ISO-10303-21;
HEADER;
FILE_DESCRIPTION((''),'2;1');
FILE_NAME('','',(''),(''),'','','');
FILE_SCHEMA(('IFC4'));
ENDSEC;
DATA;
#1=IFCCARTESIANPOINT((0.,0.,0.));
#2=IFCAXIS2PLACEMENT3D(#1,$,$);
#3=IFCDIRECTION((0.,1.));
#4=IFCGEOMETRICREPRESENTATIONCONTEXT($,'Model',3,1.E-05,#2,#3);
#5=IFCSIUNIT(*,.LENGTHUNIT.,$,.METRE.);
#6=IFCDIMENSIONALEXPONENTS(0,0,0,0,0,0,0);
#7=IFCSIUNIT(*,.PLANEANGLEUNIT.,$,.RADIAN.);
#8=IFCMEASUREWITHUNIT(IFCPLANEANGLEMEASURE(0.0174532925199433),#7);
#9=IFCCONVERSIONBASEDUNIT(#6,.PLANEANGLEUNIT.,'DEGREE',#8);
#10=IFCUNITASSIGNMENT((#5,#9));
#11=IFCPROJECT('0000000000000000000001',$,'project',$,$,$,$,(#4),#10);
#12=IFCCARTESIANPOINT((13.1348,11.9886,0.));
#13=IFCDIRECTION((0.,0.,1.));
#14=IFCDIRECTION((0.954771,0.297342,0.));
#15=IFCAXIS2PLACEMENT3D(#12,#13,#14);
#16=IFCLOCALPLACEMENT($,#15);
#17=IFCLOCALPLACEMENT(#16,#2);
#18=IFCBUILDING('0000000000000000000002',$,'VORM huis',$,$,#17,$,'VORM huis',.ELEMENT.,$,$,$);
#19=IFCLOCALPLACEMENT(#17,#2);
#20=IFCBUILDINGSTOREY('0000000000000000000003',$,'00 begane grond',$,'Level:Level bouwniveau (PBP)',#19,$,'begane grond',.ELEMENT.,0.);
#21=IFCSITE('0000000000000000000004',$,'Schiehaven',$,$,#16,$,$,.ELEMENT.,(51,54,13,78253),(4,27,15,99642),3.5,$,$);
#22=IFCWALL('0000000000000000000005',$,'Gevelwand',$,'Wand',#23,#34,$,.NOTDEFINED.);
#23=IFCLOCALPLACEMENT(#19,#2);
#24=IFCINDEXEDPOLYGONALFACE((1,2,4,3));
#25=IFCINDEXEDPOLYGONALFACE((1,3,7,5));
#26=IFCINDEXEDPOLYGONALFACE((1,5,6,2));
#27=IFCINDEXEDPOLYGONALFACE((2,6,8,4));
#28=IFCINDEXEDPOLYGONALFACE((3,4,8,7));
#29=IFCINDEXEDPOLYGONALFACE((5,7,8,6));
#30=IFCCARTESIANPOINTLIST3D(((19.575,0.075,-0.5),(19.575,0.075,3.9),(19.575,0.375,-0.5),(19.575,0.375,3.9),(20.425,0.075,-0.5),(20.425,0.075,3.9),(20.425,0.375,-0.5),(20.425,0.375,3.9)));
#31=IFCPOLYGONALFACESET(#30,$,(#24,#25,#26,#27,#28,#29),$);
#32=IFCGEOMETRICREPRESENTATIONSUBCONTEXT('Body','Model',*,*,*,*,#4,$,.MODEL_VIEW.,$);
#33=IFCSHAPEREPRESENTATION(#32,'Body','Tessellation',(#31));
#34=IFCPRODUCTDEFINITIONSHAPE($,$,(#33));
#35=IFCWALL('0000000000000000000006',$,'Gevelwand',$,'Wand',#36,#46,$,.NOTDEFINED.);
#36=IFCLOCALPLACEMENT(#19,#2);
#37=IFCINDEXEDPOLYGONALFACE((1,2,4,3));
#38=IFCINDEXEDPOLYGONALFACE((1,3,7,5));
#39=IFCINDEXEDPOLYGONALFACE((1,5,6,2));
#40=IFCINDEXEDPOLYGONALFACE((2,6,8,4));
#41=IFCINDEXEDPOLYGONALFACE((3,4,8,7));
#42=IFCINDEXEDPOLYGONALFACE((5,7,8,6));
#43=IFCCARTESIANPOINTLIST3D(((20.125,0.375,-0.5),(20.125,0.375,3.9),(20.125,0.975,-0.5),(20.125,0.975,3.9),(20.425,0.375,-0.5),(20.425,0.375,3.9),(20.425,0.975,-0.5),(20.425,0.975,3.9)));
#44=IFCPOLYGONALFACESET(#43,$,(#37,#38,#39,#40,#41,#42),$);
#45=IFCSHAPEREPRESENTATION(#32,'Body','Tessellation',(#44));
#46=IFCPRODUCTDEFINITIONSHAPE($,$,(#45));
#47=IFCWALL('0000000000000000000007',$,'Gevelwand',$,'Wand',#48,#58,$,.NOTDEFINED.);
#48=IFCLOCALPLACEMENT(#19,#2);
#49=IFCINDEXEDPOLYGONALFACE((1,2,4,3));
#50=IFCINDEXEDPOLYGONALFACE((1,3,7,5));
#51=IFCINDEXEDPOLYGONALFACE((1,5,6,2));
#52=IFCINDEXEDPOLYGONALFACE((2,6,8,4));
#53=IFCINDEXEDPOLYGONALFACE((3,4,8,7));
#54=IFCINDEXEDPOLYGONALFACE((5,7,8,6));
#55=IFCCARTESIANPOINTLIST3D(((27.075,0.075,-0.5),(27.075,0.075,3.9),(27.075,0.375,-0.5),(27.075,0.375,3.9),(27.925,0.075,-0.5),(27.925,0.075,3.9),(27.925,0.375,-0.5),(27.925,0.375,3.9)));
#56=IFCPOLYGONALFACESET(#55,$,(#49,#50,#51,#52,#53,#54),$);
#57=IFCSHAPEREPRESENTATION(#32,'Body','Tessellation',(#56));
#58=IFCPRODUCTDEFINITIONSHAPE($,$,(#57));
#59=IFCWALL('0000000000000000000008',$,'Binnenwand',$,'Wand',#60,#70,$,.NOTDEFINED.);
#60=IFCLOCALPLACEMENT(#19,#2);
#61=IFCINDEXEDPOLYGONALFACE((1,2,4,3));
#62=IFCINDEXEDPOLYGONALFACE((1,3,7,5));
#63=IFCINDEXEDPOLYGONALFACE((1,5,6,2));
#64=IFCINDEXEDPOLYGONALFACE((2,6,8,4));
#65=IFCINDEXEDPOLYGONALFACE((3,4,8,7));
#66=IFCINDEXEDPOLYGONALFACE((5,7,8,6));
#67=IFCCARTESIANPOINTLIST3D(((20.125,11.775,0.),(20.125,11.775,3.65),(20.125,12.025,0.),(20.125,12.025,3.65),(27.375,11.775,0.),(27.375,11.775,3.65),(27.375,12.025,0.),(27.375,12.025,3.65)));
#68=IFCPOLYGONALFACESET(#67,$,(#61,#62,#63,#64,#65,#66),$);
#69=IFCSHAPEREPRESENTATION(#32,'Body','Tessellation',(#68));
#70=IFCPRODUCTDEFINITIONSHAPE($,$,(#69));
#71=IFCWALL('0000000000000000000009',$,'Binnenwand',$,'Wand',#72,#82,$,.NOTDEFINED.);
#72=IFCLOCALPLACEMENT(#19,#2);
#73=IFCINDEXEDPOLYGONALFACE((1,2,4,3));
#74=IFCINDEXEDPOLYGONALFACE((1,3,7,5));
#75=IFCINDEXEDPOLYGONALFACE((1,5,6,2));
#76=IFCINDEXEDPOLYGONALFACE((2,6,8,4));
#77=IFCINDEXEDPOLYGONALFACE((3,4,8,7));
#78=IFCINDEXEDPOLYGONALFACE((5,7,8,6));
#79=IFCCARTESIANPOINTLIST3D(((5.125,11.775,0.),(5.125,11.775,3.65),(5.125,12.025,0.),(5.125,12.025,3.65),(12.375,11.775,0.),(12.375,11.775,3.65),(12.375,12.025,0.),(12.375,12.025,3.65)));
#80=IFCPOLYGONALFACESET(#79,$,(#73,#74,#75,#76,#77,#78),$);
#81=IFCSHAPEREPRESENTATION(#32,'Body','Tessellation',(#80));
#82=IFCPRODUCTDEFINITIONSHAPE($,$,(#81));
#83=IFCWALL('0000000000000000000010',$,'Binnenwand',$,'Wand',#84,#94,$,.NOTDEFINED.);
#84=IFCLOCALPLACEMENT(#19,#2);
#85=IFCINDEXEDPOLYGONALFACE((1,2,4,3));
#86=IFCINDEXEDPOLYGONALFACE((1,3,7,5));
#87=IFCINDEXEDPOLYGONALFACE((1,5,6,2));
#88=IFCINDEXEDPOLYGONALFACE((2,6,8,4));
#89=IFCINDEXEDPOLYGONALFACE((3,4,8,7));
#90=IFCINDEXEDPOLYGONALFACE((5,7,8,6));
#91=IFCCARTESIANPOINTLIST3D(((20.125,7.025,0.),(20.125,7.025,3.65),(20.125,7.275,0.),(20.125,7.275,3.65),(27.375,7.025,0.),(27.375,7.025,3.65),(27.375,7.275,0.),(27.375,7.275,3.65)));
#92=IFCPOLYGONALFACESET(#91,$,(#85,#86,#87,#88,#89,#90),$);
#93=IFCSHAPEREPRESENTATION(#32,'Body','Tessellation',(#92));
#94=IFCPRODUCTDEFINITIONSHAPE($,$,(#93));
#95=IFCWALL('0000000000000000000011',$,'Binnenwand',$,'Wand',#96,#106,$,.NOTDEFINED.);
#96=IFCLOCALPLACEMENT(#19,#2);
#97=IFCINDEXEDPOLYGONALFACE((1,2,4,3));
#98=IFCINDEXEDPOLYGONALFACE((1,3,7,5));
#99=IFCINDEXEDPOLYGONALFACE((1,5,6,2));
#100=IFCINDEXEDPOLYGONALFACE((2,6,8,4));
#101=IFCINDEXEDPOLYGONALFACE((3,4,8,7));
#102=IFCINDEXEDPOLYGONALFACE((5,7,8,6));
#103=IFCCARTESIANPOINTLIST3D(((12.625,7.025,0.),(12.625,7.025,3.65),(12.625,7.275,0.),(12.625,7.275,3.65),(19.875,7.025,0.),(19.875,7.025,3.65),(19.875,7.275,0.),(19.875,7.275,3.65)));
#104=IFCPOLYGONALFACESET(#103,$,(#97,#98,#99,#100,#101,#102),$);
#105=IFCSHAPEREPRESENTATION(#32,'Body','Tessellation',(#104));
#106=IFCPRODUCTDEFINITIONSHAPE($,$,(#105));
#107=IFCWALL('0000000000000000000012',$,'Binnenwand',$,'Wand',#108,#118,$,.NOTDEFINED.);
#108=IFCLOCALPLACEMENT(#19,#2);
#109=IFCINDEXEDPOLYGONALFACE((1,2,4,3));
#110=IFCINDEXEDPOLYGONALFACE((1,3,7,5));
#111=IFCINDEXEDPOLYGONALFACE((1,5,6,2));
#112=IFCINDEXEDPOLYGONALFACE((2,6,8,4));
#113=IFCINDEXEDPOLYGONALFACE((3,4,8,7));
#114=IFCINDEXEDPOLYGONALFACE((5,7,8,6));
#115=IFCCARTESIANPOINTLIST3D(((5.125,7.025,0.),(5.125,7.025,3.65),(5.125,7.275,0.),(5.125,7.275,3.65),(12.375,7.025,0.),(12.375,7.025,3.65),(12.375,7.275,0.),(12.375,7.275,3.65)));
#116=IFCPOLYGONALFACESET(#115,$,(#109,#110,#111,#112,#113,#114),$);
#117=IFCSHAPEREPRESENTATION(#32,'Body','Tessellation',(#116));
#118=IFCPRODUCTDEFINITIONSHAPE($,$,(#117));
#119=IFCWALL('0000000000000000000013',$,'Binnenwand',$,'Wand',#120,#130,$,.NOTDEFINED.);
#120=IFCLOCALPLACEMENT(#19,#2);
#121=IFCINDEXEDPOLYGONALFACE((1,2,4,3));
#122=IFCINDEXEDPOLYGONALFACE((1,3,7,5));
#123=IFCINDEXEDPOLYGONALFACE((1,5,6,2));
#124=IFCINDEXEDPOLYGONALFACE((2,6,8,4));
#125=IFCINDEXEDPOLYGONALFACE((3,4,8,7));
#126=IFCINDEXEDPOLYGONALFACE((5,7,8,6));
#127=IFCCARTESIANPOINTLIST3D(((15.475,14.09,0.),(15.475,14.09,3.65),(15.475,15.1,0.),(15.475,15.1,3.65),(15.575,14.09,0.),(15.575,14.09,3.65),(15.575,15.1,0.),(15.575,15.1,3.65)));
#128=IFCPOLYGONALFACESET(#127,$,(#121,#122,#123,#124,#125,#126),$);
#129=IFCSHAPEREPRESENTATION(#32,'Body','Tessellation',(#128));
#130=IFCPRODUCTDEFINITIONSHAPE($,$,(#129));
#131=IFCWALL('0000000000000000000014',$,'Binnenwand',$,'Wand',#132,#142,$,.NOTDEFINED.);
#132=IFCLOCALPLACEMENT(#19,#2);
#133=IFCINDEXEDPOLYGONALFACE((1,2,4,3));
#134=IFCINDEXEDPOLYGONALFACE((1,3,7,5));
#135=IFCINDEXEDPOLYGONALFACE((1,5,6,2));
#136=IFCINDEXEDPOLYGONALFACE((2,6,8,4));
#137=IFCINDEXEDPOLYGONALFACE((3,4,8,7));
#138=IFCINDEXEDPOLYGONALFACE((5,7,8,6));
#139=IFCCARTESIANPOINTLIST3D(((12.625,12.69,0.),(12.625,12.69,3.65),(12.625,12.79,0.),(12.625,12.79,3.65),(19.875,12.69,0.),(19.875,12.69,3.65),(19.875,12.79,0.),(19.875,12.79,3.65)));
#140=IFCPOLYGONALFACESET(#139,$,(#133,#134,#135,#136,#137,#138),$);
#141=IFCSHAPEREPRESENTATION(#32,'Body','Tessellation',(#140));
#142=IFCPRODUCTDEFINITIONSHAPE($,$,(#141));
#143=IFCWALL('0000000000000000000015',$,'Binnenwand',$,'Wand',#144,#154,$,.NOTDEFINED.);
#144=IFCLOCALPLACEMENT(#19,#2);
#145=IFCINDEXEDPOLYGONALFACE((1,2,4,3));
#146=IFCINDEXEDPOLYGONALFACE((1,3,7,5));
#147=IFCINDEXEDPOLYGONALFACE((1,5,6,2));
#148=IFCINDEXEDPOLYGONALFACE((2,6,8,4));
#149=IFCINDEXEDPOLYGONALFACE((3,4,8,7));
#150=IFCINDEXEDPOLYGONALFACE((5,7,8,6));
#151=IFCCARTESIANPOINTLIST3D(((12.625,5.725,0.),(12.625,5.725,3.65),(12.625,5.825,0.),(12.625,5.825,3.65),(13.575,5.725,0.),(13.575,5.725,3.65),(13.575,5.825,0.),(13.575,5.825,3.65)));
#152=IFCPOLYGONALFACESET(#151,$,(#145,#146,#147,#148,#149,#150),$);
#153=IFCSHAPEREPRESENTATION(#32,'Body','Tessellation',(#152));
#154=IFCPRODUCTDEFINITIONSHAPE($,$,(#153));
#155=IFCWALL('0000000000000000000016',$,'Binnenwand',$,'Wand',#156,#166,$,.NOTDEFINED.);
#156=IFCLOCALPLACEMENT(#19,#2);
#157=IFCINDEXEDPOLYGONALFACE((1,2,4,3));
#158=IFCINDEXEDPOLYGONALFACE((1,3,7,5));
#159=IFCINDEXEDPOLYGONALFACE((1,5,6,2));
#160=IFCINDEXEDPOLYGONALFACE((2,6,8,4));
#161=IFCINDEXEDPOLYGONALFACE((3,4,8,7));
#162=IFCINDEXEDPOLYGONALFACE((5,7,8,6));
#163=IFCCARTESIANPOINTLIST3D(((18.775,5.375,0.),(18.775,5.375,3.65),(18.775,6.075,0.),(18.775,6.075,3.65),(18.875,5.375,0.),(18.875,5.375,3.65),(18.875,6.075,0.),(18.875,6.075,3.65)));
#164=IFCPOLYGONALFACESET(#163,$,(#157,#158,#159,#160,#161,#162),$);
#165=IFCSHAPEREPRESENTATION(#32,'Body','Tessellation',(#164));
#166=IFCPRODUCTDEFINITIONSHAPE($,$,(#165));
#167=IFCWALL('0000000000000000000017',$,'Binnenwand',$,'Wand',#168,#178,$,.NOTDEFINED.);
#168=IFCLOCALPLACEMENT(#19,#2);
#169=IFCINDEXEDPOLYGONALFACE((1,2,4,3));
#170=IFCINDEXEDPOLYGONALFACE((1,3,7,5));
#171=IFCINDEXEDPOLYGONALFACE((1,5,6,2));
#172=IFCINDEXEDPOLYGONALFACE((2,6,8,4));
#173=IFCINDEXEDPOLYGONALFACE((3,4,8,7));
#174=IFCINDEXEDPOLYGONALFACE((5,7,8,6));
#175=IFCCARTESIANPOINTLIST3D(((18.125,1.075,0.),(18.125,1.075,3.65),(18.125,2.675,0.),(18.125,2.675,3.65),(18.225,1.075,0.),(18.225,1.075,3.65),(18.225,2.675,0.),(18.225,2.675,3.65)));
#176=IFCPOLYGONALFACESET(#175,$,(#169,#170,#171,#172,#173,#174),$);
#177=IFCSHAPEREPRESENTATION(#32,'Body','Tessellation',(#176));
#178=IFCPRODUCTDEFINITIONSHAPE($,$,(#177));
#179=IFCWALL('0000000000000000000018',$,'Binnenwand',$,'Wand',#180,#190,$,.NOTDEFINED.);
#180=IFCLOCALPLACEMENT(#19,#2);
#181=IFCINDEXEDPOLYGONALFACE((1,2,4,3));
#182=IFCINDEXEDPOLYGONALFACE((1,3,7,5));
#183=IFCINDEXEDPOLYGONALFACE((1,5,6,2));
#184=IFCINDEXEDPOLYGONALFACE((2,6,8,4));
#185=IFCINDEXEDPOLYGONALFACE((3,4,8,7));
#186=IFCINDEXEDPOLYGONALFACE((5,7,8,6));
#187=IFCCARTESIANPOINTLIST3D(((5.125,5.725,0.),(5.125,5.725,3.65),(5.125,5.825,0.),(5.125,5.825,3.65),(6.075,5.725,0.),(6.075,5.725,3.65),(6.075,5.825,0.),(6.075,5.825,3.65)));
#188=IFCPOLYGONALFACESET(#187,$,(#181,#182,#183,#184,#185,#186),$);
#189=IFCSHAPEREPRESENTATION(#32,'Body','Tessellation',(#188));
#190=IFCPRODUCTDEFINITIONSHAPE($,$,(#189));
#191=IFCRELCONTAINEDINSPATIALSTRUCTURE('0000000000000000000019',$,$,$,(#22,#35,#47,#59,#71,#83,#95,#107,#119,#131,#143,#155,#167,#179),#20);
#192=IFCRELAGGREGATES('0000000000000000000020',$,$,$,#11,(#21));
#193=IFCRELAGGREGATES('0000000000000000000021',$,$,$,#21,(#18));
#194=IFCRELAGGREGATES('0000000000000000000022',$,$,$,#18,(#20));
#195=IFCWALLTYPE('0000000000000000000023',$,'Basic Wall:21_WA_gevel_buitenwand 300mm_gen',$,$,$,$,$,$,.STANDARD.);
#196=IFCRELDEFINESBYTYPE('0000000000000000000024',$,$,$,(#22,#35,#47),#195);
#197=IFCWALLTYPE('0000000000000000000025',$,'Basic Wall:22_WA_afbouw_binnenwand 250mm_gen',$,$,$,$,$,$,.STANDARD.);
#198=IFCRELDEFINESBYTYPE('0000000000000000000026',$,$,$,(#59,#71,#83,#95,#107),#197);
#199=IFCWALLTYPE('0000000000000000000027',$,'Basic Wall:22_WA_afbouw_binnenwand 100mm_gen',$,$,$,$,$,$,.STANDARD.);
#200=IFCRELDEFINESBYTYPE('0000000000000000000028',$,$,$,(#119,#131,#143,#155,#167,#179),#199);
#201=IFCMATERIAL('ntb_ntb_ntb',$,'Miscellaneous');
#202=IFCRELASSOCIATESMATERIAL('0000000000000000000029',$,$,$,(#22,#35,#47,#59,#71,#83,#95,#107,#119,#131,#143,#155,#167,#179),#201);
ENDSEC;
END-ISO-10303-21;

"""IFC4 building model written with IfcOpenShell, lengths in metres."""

from ifc_helpers import new_model, entity, si_unit, converted_unit, direction, frame, origin, place, context, subcontext, project, spatial, indexed_curve, outline, extrude, material, type_object, element, save


model = new_model("IFC4")

# Units and contexts
model_context = context("Model", 3, precision=1e-05, world=origin(), true_north=direction((0.0, 1.0)))
body_context = subcontext(model_context, "Body", "Model", "MODEL_VIEW")
ifc_project = project(units=[si_unit("LENGTHUNIT", "METRE"), converted_unit("PLANEANGLEUNIT", "DEGREE", entity("IfcPlaneAngleMeasure", 0.0174532925199433), si_unit("PLANEANGLEUNIT", "RADIAN"), dimensions=[0, 0, 0, 0, 0, 0, 0])], contexts=[model_context])

# Site, building, storey
site_placement = place(None, frame((13.1348, 11.9886, 0.0), z_axis=(0.0, 0.0, 1.0), x_axis=(0.954771, 0.297342, 0.0)))
site = spatial("IfcSite", under=ifc_project, at=site_placement, Name="Schiehaven", CompositionType="ELEMENT", RefLatitude=(51, 54, 13, 78253), RefLongitude=(4, 27, 15, 99642), RefElevation=3.5)
building_placement = place(site_placement, origin())
building = spatial("IfcBuilding", under=site, at=building_placement, Name="VORM huis", LongName="VORM huis", CompositionType="ELEMENT")
storey_placement = place(building_placement, origin())
storey = spatial("IfcBuildingStorey", under=building, at=storey_placement, Name="00 begane grond", ObjectType="Level:Level bouwniveau (PBP)", LongName="begane grond", CompositionType="ELEMENT", Elevation=0.0)

# Walls
ifc_material_1 = material(Name="ntb_ntb_ntb", Category="Miscellaneous")
wall_type_1 = type_object("IfcWallType", Name="Basic Wall:21_WA_gevel_buitenwand 300mm_gen", PredefinedType="STANDARD")
wall_1_placement = place(storey_placement, frame((20.425, 0.225, -0.5), z_axis=(0.0, 0.0, 1.0), x_axis=(-1.0, 0.0, 0.0)))
element("IfcWall", 1, at=wall_1_placement, inside=storey, type_object=wall_type_1, material=ifc_material_1, Name="Gevelwand", ObjectType="Wand", PredefinedType="NOTDEFINED", context=body_context, shape_type="SweptSolid", body=[
    extrude(outline(indexed_curve([(0.85, 0.15), (0.0, 0.15), (0.0, -0.15), (0.85, -0.15), (0.85, 0.15)], self_intersect=False)), origin(), (0.0, 0.0, 1.0), 4.4),
])
wall_2_placement = place(storey_placement, frame((20.275, 0.975, -0.5), z_axis=(0.0, 0.0, 1.0), x_axis=(0.0, -1.0, 0.0)))
element("IfcWall", 2, at=wall_2_placement, inside=storey, type_object=wall_type_1, material=ifc_material_1, Name="Gevelwand", ObjectType="Wand", PredefinedType="NOTDEFINED", context=body_context, shape_type="SweptSolid", body=[
    extrude(outline(indexed_curve([(0.6, 0.15), (0.0, 0.15), (0.0, -0.15), (0.6, -0.15), (0.6, 0.15)], self_intersect=False)), origin(), (0.0, 0.0, 1.0), 4.4),
])
wall_3_placement = place(storey_placement, frame((27.925, 0.225, -0.5), z_axis=(0.0, 0.0, 1.0), x_axis=(-1.0, 0.0, 0.0)))
element("IfcWall", 3, at=wall_3_placement, inside=storey, type_object=wall_type_1, material=ifc_material_1, Name="Gevelwand", ObjectType="Wand", PredefinedType="NOTDEFINED", context=body_context, shape_type="SweptSolid", body=[
    extrude(outline(indexed_curve([(0.85, 0.15), (0.0, 0.15), (0.0, -0.15), (0.85, -0.15), (0.85, 0.15)], self_intersect=False)), origin(), (0.0, 0.0, 1.0), 4.4),
])
wall_type_2 = type_object("IfcWallType", Name="Basic Wall:22_WA_afbouw_binnenwand 250mm_gen", PredefinedType="STANDARD")
wall_4_placement = place(storey_placement, frame((20.125, 11.9, 0.0)))
element("IfcWall", 4, at=wall_4_placement, inside=storey, type_object=wall_type_2, material=ifc_material_1, Name="Binnenwand", ObjectType="Wand", PredefinedType="NOTDEFINED", context=body_context, shape_type="SweptSolid", body=[
    extrude(outline(indexed_curve([(7.25, 0.125), (0.0, 0.125), (0.0, -0.125), (7.25, -0.125), (7.25, 0.125)], self_intersect=False)), origin(), (0.0, 0.0, 1.0), 3.65),
])
wall_5_placement = place(storey_placement, frame((12.375, 11.9, 0.0), z_axis=(0.0, 0.0, 1.0), x_axis=(-1.0, 0.0, 0.0)))
element("IfcWall", 5, at=wall_5_placement, inside=storey, type_object=wall_type_2, material=ifc_material_1, Name="Binnenwand", ObjectType="Wand", PredefinedType="NOTDEFINED", context=body_context, shape_type="SweptSolid", body=[
    extrude(outline(indexed_curve([(7.25, 0.125), (0.0, 0.125), (0.0, -0.125), (7.25, -0.125), (7.25, 0.125)], self_intersect=False)), origin(), (0.0, 0.0, 1.0), 3.65),
])
for number, where, name in (
    (6, (20.125, 7.15, 0.0), "Binnenwand"),
    (7, (12.625, 7.15, 0.0), "Binnenwand"),
    (8, (5.125, 7.15, 0.0), "Binnenwand"),
):
    element("IfcWall", number, at=place(storey_placement, frame(where)), inside=storey, type_object=wall_type_2, material=ifc_material_1, Name=name, ObjectType="Wand", PredefinedType="NOTDEFINED", context=body_context, shape_type="SweptSolid", body=[
        extrude(outline(indexed_curve([(7.25, 0.125), (0.0, 0.125), (0.0, -0.125), (7.25, -0.125), (7.25, 0.125)], self_intersect=False)), origin(), (0.0, 0.0, 1.0), 3.65),
    ])
wall_type_3 = type_object("IfcWallType", Name="Basic Wall:22_WA_afbouw_binnenwand 100mm_gen", PredefinedType="STANDARD")
wall_6_placement = place(storey_placement, frame((15.525, 14.09, 0.0), z_axis=(0.0, 0.0, 1.0), x_axis=(0.0, 1.0, 0.0)))
element("IfcWall", 9, at=wall_6_placement, inside=storey, type_object=wall_type_3, material=ifc_material_1, Name="Binnenwand", ObjectType="Wand", PredefinedType="NOTDEFINED", context=body_context, shape_type="SweptSolid", body=[
    extrude(outline(indexed_curve([(1.01, 0.05), (0.0, 0.05), (0.0, -0.05), (1.01, -0.05), (1.01, 0.05)], self_intersect=False)), origin(), (0.0, 0.0, 1.0), 3.65),
])
wall_7_placement = place(storey_placement, frame((19.875, 12.74, 0.0), z_axis=(0.0, 0.0, 1.0), x_axis=(-1.0, 0.0, 0.0)))
element("IfcWall", 10, at=wall_7_placement, inside=storey, type_object=wall_type_3, material=ifc_material_1, Name="Binnenwand", ObjectType="Wand", PredefinedType="NOTDEFINED", context=body_context, shape_type="SweptSolid", body=[
    extrude(outline(indexed_curve([(7.25, 0.05), (0.0, 0.05), (0.0, -0.05), (7.25, -0.05), (7.25, 0.05)], self_intersect=False)), origin(), (0.0, 0.0, 1.0), 3.65),
])
wall_8_placement = place(storey_placement, frame((12.625, 5.775, 0.0)))
element("IfcWall", 11, at=wall_8_placement, inside=storey, type_object=wall_type_3, material=ifc_material_1, Name="Binnenwand", ObjectType="Wand", PredefinedType="NOTDEFINED", context=body_context, shape_type="SweptSolid", body=[
    extrude(outline(indexed_curve([(0.95, 0.05), (0.0, 0.05), (0.0, -0.05), (0.95, -0.05), (0.95, 0.05)], self_intersect=False)), origin(), (0.0, 0.0, 1.0), 3.65),
])
wall_9_placement = place(storey_placement, frame((18.825, 6.075, 0.0), z_axis=(0.0, 0.0, 1.0), x_axis=(0.0, -1.0, 0.0)))
element("IfcWall", 12, at=wall_9_placement, inside=storey, type_object=wall_type_3, material=ifc_material_1, Name="Binnenwand", ObjectType="Wand", PredefinedType="NOTDEFINED", context=body_context, shape_type="SweptSolid", body=[
    extrude(outline(indexed_curve([(0.7, 0.05), (0.0, 0.05), (0.0, -0.05), (0.7, -0.05), (0.7, 0.05)], self_intersect=False)), origin(), (0.0, 0.0, 1.0), 3.65),
])
wall_10_placement = place(storey_placement, frame((18.175, 2.675, 0.0), z_axis=(0.0, 0.0, 1.0), x_axis=(0.0, -1.0, 0.0)))
element("IfcWall", 13, at=wall_10_placement, inside=storey, type_object=wall_type_3, material=ifc_material_1, Name="Binnenwand", ObjectType="Wand", PredefinedType="NOTDEFINED", context=body_context, shape_type="SweptSolid", body=[
    extrude(outline(indexed_curve([(1.6, 0.05), (0.0, 0.05), (0.0, -0.05), (1.6, -0.05), (1.6, 0.05)], self_intersect=False)), origin(), (0.0, 0.0, 1.0), 3.65),
])
wall_11_placement = place(storey_placement, frame((5.125, 5.775, 0.0)))
element("IfcWall", 14, at=wall_11_placement, inside=storey, type_object=wall_type_3, material=ifc_material_1, Name="Binnenwand", ObjectType="Wand", PredefinedType="NOTDEFINED", context=body_context, shape_type="SweptSolid", body=[
    extrude(outline(indexed_curve([(0.95, 0.05), (0.0, 0.05), (0.0, -0.05), (0.95, -0.05), (0.95, 0.05)], self_intersect=False)), origin(), (0.0, 0.0, 1.0), 3.65),
])

save(model, "model.ifc")
